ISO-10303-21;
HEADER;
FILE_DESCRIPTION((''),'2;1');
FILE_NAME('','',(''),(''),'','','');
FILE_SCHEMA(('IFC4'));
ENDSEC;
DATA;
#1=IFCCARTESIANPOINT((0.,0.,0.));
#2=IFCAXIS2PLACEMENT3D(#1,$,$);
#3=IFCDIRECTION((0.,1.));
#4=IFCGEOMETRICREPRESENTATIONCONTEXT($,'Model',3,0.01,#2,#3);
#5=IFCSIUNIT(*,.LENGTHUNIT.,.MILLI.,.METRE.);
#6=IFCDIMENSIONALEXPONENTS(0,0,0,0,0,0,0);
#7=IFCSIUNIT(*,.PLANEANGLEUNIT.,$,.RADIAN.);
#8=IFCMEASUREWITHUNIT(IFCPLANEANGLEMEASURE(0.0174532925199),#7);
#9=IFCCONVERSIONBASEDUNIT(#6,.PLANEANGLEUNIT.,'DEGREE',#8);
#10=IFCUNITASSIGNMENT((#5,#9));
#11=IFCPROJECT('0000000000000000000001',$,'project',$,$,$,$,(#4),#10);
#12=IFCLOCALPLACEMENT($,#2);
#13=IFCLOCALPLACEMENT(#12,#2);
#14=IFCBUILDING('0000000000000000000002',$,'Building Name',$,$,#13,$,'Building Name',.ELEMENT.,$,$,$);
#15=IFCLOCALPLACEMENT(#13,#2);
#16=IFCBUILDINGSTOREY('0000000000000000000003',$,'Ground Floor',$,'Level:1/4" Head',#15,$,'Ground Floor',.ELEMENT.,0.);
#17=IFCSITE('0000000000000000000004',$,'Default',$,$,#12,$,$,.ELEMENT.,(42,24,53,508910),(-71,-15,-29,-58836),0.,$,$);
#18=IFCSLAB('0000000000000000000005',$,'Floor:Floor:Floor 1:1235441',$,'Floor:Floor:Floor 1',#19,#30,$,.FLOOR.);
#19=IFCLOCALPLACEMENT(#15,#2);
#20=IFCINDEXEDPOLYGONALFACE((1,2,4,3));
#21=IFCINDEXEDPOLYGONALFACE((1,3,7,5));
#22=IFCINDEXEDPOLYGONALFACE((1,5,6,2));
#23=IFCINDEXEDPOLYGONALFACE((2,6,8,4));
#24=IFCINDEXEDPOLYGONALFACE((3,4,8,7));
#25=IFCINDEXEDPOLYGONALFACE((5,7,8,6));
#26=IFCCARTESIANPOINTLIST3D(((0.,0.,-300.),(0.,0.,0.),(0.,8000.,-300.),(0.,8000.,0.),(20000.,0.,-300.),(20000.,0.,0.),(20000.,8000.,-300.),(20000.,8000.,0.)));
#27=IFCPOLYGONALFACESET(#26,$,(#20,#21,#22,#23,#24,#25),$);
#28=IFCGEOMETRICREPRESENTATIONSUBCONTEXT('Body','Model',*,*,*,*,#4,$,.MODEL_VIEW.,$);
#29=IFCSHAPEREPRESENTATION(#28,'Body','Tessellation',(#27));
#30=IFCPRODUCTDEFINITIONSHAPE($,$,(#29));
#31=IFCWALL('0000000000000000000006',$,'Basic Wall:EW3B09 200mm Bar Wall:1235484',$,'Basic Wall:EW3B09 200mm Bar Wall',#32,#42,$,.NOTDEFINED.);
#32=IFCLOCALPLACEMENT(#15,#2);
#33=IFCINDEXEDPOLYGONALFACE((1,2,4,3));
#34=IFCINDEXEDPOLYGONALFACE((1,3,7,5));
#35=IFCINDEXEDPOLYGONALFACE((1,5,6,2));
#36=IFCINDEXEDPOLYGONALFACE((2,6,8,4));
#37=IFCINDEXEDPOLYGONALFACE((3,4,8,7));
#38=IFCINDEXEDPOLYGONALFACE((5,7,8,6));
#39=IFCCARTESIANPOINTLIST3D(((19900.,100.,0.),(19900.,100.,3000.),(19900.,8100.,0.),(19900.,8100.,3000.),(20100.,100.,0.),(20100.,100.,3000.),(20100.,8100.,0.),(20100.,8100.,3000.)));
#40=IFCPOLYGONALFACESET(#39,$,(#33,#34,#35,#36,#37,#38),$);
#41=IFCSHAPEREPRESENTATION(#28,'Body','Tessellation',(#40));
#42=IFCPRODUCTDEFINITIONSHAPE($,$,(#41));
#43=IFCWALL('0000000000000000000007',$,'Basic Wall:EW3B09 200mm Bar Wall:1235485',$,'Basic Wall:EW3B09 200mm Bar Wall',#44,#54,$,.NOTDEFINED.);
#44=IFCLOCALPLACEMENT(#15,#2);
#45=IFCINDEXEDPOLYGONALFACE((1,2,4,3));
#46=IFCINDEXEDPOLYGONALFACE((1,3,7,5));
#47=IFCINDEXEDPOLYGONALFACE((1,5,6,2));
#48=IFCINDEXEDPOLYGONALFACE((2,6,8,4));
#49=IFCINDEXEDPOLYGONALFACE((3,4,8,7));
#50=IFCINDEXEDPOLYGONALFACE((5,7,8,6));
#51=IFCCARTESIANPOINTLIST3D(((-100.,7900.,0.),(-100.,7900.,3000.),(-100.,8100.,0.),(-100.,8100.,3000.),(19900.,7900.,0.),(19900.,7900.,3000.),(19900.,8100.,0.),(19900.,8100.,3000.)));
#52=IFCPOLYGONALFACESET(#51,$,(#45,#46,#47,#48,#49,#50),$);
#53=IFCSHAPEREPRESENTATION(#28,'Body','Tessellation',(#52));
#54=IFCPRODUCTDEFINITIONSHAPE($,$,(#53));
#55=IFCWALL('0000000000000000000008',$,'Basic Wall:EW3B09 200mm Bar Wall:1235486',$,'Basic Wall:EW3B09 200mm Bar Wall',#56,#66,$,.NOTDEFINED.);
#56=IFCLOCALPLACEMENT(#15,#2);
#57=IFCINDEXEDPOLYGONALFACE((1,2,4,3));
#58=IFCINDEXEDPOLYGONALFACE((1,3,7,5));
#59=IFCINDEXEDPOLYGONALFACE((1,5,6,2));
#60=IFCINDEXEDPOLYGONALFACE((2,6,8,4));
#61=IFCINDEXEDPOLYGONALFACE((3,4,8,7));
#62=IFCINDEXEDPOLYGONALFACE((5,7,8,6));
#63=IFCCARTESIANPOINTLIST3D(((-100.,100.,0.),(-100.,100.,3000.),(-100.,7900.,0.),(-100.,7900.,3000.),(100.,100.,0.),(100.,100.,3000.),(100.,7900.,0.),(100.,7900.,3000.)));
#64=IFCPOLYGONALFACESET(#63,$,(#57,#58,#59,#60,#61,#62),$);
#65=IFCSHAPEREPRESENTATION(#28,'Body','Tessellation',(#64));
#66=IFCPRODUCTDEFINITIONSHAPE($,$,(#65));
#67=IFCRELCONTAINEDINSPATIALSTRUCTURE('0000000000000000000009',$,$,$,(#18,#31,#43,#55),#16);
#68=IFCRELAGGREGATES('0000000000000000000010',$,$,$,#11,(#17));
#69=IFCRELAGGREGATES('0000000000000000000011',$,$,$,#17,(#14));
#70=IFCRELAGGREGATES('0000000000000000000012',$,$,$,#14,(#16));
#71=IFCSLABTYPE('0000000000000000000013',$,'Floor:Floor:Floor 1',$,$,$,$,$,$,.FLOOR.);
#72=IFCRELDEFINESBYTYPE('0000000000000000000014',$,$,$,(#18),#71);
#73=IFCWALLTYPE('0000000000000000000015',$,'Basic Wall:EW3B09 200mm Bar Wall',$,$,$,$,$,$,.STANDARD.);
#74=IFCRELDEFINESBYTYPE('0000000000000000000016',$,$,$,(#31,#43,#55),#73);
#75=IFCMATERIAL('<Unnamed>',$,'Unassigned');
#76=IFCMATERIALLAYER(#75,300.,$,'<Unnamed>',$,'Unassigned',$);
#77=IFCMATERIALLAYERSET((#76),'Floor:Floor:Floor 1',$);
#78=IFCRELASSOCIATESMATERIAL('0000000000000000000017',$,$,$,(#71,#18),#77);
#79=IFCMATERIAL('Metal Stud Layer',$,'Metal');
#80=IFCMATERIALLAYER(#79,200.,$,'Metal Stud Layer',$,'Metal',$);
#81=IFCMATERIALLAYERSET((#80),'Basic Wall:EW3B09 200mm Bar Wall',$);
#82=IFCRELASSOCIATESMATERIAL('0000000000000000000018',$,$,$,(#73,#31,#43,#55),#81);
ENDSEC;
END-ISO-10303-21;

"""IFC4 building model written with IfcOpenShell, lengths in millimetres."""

from ifc_helpers import new_model, entity, si_unit, converted_unit, direction, frame, frame_2d, origin, origin_2d_with_axis, place, context, subcontext, project, spatial, rectangle, extrude, material, layer, layer_set, layer_usage, type_object, element, save


model = new_model("IFC4")

# Units and contexts
model_context = context("Model", 3, precision=0.01, world=origin(), true_north=direction((0.0, 1.0)))
body_context = subcontext(model_context, "Body", "Model", "MODEL_VIEW")
ifc_project = project(units=[si_unit("LENGTHUNIT", "METRE", prefix="MILLI"), converted_unit("PLANEANGLEUNIT", "DEGREE", entity("IfcPlaneAngleMeasure", 0.0174532925199), si_unit("PLANEANGLEUNIT", "RADIAN"), dimensions=[0, 0, 0, 0, 0, 0, 0])], contexts=[model_context])

# Site, building, storey
site_placement = place(None, origin())
site = spatial("IfcSite", under=ifc_project, at=site_placement, Name="Default", CompositionType="ELEMENT", RefLatitude=(42, 24, 53, 508910), RefLongitude=(-71, -15, -29, -58836), RefElevation=0.0)
building_placement = place(site_placement, origin())
building = spatial("IfcBuilding", under=site, at=building_placement, Name="Building Name", LongName="Building Name", CompositionType="ELEMENT")
storey_placement = place(building_placement, origin())
storey = spatial("IfcBuildingStorey", under=building, at=storey_placement, Name="Ground Floor", ObjectType="Level:1/4\" Head", LongName="Ground Floor", CompositionType="ELEMENT", Elevation=0.0)

# Slab
ifc_material_1 = material(Name="<Unnamed>", Category="Unassigned")
ifc_layer_1 = layer(ifc_material_1, 300.0, Name="<Unnamed>", Category="Unassigned")
ifc_layer_set_1 = layer_set([ifc_layer_1], Name="Floor:Floor:Floor 1")
ifc_layer_usage_1 = layer_usage(ifc_layer_set_1, "AXIS3", "POSITIVE", 0.0)
slab_type = type_object("IfcSlabType", Name="Floor:Floor:Floor 1", PredefinedType="FLOOR", material=ifc_layer_set_1)
slab_placement = place(storey_placement, origin())
element("IfcSlab", 1, at=slab_placement, inside=storey, type_object=slab_type, material=ifc_layer_usage_1, Name="Floor:Floor:Floor 1:1235441", ObjectType="Floor:Floor:Floor 1", PredefinedType="FLOOR", context=body_context, shape_type="SweptSolid", body=[
    extrude(rectangle(XDim=8000.0, YDim=20000.0, at=origin_2d_with_axis()), frame((10000.0, 4000.0, 0.0), z_axis=(0.0, 0.0, -1.0), x_axis=(0.0, 1.0, 0.0)), (0.0, 0.0, 1.0), 300.0),
])

# Shared definitions
ifc_material_2 = material(Name="Metal Stud Layer", Category="Metal")
ifc_layer_2 = layer(ifc_material_2, 200.0, Name="Metal Stud Layer", Category="Metal")
ifc_layer_set_2 = layer_set([ifc_layer_2], Name="Basic Wall:EW3B09 200mm Bar Wall")
wall_type = type_object("IfcWallType", Name="Basic Wall:EW3B09 200mm Bar Wall", PredefinedType="STANDARD", material=ifc_layer_set_2)

# Walls
ifc_layer_usage_2 = layer_usage(ifc_layer_set_2, "AXIS2", "NEGATIVE", 100.0)
wall_1_placement = place(storey_placement, frame((20000.0, 100.0, 0.0), z_axis=(0.0, 0.0, 1.0), x_axis=(0.0, 1.0, 0.0)))
element("IfcWall", 2, at=wall_1_placement, inside=storey, type_object=wall_type, material=ifc_layer_usage_2, Name="Basic Wall:EW3B09 200mm Bar Wall:1235484", ObjectType="Basic Wall:EW3B09 200mm Bar Wall", PredefinedType="NOTDEFINED", context=body_context, shape_type="SweptSolid", body=[
    extrude(rectangle(XDim=8000.0, YDim=200.0, at=frame_2d((4000.0, 0.0), x_axis=(-1.0, 0.0))), origin(), (0.0, 0.0, 1.0), 3000.0),
])
ifc_layer_usage_3 = layer_usage(ifc_layer_set_2, "AXIS2", "NEGATIVE", 100.0)
wall_2_placement = place(storey_placement, frame((19900.0, 8000.0, 0.0), z_axis=(0.0, 0.0, 1.0), x_axis=(-1.0, 0.0, 0.0)))
element("IfcWall", 3, at=wall_2_placement, inside=storey, type_object=wall_type, material=ifc_layer_usage_3, Name="Basic Wall:EW3B09 200mm Bar Wall:1235485", ObjectType="Basic Wall:EW3B09 200mm Bar Wall", PredefinedType="NOTDEFINED", context=body_context, shape_type="SweptSolid", body=[
    extrude(rectangle(XDim=20000.0, YDim=200.0, at=frame_2d((10000.0, 0.0), x_axis=(-1.0, 0.0))), origin(), (0.0, 0.0, 1.0), 3000.0),
])
ifc_layer_usage_4 = layer_usage(ifc_layer_set_2, "AXIS2", "NEGATIVE", 100.0)
wall_3_placement = place(storey_placement, frame((0.0, 7900.0, 0.0), z_axis=(0.0, 0.0, 1.0), x_axis=(0.0, -1.0, 0.0)))
element("IfcWall", 4, at=wall_3_placement, inside=storey, type_object=wall_type, material=ifc_layer_usage_4, Name="Basic Wall:EW3B09 200mm Bar Wall:1235486", ObjectType="Basic Wall:EW3B09 200mm Bar Wall", PredefinedType="NOTDEFINED", context=body_context, shape_type="SweptSolid", body=[
    extrude(rectangle(XDim=7800.0, YDim=200.0, at=frame_2d((3900.0, 0.0), x_axis=(-1.0, 0.0))), origin(), (0.0, 0.0, 1.0), 3000.0),
])

save(model, "model.ifc")
